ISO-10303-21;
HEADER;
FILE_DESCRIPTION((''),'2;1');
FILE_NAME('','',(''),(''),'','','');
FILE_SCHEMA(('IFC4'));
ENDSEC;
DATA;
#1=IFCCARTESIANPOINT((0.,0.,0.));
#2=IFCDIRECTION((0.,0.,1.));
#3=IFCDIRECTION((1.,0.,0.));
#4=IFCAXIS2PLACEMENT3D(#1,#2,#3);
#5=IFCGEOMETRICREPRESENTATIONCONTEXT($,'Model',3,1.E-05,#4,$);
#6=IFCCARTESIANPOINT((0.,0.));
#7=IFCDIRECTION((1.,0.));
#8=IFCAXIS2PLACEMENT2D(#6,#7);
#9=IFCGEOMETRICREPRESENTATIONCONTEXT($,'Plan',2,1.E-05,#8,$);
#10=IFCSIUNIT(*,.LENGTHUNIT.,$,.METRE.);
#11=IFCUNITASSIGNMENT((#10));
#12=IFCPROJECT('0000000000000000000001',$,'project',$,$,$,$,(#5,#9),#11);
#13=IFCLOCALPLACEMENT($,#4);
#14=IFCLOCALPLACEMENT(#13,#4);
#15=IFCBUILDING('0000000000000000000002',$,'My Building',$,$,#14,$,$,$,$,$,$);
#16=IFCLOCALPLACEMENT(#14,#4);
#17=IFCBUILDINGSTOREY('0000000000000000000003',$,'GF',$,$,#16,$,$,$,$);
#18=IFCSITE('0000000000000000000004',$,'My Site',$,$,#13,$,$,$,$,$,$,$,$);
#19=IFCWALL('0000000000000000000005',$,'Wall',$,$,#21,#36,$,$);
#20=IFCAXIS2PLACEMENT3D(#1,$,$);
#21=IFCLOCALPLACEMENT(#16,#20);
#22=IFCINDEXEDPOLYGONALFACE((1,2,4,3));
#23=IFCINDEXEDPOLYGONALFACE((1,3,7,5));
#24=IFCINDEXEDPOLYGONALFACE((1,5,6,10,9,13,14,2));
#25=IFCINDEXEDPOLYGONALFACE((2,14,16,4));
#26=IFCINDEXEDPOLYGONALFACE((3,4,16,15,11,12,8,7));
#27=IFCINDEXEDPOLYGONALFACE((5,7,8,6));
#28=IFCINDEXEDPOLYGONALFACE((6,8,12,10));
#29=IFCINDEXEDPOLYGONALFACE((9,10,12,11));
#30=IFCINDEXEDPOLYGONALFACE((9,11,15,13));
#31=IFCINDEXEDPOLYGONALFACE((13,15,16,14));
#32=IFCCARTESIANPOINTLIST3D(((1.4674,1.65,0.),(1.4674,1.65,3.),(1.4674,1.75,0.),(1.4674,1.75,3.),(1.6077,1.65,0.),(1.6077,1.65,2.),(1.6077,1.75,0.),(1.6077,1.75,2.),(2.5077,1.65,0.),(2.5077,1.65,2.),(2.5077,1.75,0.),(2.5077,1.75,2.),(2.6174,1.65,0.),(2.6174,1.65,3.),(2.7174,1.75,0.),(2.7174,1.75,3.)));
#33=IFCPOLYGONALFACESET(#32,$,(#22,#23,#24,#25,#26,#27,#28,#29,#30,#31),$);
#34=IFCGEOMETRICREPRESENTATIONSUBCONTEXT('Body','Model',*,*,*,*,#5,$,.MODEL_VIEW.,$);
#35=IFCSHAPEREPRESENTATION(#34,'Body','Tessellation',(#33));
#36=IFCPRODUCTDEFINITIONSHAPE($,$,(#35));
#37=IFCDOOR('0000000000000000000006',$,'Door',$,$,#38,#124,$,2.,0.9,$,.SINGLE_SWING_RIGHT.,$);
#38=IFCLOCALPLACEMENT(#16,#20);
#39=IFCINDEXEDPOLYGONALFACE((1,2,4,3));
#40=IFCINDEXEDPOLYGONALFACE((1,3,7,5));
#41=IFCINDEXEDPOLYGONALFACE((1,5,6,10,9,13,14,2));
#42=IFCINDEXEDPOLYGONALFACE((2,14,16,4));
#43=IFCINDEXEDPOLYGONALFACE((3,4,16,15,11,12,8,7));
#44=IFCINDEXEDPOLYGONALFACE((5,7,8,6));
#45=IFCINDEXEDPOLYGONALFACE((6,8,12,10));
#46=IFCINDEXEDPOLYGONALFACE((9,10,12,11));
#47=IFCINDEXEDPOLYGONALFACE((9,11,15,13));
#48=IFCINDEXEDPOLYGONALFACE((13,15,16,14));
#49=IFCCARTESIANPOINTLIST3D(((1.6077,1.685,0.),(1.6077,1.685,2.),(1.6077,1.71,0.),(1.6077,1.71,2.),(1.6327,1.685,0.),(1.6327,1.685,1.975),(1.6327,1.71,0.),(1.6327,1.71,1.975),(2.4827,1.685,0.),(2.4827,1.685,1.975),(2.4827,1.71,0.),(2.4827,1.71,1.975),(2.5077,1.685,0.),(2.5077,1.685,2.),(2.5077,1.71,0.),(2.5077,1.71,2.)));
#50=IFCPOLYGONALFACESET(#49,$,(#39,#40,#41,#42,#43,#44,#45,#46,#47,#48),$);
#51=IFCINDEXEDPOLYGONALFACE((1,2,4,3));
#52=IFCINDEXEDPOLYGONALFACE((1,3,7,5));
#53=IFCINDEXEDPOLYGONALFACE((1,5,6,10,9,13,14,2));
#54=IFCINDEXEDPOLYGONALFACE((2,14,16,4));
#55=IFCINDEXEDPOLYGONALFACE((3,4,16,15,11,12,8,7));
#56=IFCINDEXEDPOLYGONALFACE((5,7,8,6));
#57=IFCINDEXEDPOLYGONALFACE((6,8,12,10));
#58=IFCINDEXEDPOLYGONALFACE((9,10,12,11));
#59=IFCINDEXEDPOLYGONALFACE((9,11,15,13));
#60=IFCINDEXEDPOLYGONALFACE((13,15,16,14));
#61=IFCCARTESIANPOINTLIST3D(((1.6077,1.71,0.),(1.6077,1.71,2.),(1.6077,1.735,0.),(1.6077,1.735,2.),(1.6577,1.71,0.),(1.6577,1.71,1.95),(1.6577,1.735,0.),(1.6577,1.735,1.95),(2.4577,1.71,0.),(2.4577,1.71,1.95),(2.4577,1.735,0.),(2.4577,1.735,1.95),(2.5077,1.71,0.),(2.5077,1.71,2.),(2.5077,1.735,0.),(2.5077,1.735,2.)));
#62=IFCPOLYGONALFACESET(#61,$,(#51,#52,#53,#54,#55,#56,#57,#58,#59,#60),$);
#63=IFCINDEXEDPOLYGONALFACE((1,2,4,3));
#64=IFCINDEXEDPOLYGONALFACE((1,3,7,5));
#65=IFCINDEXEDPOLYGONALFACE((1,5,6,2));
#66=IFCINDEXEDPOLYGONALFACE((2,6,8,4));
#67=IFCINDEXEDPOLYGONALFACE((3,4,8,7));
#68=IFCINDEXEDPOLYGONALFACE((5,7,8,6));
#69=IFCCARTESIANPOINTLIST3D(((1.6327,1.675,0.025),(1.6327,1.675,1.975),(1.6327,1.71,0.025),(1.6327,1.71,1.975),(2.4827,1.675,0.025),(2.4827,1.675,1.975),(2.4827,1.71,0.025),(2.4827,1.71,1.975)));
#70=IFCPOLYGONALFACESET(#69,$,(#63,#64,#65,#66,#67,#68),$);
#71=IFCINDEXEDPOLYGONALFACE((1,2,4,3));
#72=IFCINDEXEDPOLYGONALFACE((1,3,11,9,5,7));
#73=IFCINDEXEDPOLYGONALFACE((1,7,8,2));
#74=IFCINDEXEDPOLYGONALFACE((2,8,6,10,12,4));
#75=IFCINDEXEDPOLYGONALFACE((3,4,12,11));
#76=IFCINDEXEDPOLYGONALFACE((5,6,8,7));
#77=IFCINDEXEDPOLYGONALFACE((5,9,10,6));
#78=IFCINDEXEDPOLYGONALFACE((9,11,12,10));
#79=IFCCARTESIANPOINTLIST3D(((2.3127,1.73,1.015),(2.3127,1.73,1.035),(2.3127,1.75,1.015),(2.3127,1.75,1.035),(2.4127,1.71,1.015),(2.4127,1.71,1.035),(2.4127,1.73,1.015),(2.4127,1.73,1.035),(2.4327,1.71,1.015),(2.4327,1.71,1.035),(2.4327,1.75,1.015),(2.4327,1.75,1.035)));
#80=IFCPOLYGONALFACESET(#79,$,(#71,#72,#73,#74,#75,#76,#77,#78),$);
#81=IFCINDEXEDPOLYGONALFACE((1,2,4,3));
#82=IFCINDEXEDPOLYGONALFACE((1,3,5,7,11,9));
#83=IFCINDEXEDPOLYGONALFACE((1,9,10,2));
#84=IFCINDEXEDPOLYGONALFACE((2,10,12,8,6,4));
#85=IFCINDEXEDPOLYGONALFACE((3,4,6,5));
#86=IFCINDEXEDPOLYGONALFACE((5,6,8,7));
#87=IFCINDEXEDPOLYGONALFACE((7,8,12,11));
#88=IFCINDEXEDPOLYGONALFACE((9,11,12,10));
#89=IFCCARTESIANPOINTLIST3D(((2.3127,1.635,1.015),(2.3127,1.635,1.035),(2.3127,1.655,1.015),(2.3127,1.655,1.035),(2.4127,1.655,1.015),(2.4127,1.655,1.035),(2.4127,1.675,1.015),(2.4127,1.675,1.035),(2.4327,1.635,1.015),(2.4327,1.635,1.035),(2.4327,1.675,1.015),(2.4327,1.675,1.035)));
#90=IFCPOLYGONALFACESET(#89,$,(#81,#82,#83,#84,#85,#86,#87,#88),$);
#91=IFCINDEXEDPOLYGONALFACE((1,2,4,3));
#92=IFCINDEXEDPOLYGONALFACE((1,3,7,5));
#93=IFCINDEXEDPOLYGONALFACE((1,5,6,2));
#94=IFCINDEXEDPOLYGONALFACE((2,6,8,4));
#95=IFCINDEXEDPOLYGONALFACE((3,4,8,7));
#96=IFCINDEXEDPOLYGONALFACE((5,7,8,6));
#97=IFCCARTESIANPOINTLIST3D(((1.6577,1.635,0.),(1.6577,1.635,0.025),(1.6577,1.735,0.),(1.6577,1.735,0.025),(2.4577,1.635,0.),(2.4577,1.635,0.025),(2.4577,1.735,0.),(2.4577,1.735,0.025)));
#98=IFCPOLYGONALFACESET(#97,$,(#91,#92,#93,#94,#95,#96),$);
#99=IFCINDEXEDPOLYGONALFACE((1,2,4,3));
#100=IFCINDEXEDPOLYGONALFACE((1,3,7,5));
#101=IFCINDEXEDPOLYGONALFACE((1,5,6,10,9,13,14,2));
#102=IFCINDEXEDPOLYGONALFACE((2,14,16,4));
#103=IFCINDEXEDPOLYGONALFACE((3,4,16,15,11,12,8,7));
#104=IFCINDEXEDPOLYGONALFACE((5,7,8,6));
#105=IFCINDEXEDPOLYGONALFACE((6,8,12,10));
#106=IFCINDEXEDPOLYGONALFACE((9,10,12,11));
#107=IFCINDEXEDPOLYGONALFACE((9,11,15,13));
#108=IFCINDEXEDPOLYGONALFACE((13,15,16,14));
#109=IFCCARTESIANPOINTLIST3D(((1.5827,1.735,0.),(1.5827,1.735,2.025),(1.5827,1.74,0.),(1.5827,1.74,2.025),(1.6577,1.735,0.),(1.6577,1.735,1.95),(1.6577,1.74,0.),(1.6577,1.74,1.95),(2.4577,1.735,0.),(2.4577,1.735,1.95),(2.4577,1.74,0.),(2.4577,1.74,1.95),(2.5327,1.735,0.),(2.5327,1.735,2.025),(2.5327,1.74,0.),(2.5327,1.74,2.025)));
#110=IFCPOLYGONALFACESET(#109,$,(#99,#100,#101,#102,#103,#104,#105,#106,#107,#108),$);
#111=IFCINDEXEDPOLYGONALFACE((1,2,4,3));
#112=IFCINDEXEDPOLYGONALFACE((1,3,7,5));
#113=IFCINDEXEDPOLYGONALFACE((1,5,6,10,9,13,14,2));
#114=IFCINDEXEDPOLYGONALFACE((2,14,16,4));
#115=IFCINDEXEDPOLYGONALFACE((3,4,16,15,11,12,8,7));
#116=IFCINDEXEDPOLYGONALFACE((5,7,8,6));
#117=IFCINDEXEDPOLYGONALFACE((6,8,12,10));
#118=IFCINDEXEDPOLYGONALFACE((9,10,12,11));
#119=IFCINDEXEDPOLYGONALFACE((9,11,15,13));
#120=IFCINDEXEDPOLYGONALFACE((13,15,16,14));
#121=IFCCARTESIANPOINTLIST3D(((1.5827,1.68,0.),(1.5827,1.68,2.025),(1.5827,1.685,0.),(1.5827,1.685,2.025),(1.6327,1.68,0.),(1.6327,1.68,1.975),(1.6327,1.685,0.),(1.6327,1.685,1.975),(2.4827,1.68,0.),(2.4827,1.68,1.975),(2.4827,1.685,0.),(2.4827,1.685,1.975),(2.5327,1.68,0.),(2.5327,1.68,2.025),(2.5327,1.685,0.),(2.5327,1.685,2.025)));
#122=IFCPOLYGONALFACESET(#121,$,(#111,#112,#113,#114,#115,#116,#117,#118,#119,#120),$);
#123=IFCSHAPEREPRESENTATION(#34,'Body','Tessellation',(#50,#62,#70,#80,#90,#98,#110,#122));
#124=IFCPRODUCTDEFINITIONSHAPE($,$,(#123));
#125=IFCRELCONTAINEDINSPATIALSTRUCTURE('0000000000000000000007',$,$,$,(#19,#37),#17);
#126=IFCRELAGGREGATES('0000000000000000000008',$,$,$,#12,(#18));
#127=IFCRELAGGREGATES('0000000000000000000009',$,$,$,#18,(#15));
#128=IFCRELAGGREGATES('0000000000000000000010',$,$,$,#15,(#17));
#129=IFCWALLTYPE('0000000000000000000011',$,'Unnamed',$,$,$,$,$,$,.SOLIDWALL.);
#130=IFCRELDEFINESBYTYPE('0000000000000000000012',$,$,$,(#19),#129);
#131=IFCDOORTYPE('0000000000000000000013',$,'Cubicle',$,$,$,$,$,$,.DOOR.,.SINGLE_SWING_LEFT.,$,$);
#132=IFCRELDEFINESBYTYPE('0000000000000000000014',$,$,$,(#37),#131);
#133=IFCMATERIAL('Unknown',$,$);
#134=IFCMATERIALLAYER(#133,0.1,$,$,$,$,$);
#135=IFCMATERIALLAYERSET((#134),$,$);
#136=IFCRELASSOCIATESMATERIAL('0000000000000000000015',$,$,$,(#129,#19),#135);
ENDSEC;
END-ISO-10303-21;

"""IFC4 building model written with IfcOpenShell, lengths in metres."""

from ifc_helpers import new_model, entity, si_unit, frame, origin_with_axes, origin_2d_with_axis, place, context, subcontext, project, spatial, line, indexed_curve, outline, extrude, shape, source, transform, mapped, material, layer, layer_set, layer_usage, type_object, type_shapes, element, fill, save


model = new_model("IFC4")

# Units and contexts
model_context = context("Model", 3, precision=1e-05, world=origin_with_axes())
plan_context = context("Plan", 2, precision=1e-05, world=origin_2d_with_axis())
body_context_1 = subcontext(model_context, "Body", "Model", "MODEL_VIEW")
body_context_2 = subcontext(plan_context, "Body", "Plan", "PLAN_VIEW")
ifc_project = project(units=[si_unit("LENGTHUNIT", "METRE")], contexts=[model_context, plan_context])

# Site, building, storey
site_placement = place(None, origin_with_axes())
site = spatial("IfcSite", under=ifc_project, at=site_placement, Name="My Site")
building_placement = place(site_placement, origin_with_axes())
building = spatial("IfcBuilding", under=site, at=building_placement, Name="My Building")
storey_placement = place(building_placement, origin_with_axes())
storey = spatial("IfcBuildingStorey", under=building, at=storey_placement, Name="GF")

# Shared definitions
ifc_material = material(Name="Unknown")

# Shared definitions
ifc_layer_1 = layer(ifc_material, 0.1)
ifc_layer_set_1 = layer_set([ifc_layer_1])
wall_type = type_object("IfcWallType", Name="Unnamed", PredefinedType="SOLIDWALL", material=ifc_layer_set_1)

# Wall, opening, door
shared_shape_1 = source(origin_with_axes(), body_context_1, "Body", "SweptSolid", [
    extrude(outline(indexed_curve([(0.0, 0.0), (0.9, 0.0), (0.9, 2.0), (0.0, 2.0)], segments=[line(1, 2, 3, 4, 1)])), frame((0.0, -0.6, 0.0), z_axis=(0.0, -1.0, 0.0), x_axis=(1.0, 0.0, 0.0)), (0.0, 0.0, -1.0), 1.2),
])
door_type = type_object("IfcDoorType", Name="Cubicle", OperationType="SINGLE_SWING_LEFT", PredefinedType="DOOR")
shared_shape_2 = source(origin_with_axes(), body_context_1, "Body", "SweptSolid", [
    extrude(outline(indexed_curve([(0.0, 0.0), (0.0, 2.0), (0.9, 2.0), (0.9, 0.0), (0.875, 0.0), (0.875, 1.975), (0.025, 1.975), (0.025, 0.0)], segments=[line(1, 2, 3, 4, 5, 6, 7, 8, 1)])), frame((0.0, 0.025, 0.0), z_axis=(0.0, -1.0, 0.0), x_axis=(1.0, 0.0, 0.0)), (0.0, 0.0, -1.0), 0.025),
    extrude(outline(indexed_curve([(0.0, 0.0), (0.0, 2.0), (0.9, 2.0), (0.9, 0.0), (0.85, 0.0), (0.85, 1.95), (0.05, 1.95), (0.05, 0.0)], segments=[line(1, 2, 3, 4, 5, 6, 7, 8, 1)])), frame((0.0, 0.0, 0.0), z_axis=(0.0, -1.0, 0.0), x_axis=(1.0, 0.0, 0.0)), (0.0, 0.0, -1.0), 0.025),
    extrude(outline(indexed_curve([(0.0, 0.0), (0.85, 0.0), (0.85, 0.035), (0.0, 0.035)], segments=[line(1, 2, 3, 4, 1)])), frame((0.025, 0.025, 0.025), z_axis=(0.0, 0.0, 1.0), x_axis=(1.0, 0.0, 0.0)), (0.0, 0.0, 1.0), 1.95),
    extrude(outline(indexed_curve([(0.0, 0.0), (0.0, -0.04), (0.12, -0.04), (0.12, -0.02), (0.02, -0.02), (0.02, 0.0)], segments=[line(1, 2, 3, 4, 5, 6, 1)])), frame((0.075, 0.025, 1.015), z_axis=(0.0, 0.0, 1.0), x_axis=(1.0, 0.0, 0.0)), (0.0, 0.0, 1.0), 0.02),
    extrude(outline(indexed_curve([(0.0, 0.0), (0.0, 0.04), (0.12, 0.04), (0.12, 0.02), (0.02, 0.02), (0.02, 0.0)], segments=[line(1, 2, 3, 4, 5, 6, 1)])), frame((0.075, 0.06, 1.015), z_axis=(0.0, 0.0, 1.0), x_axis=(1.0, 0.0, 0.0)), (0.0, 0.0, 1.0), 0.02),
    extrude(outline(indexed_curve([(0.0, 0.0), (0.8, 0.0), (0.8, 0.1), (0.0, 0.1)], segments=[line(1, 2, 3, 4, 1)])), frame((0.05, 0.0, 0.0), z_axis=(0.0, 0.0, 1.0), x_axis=(1.0, 0.0, 0.0)), (0.0, 0.0, 1.0), 0.025),
    extrude(outline(indexed_curve([(0.0, 0.0), (0.0, 2.025), (0.95, 2.025), (0.95, 0.0), (0.875, 0.0), (0.875, 1.95), (0.075, 1.95), (0.075, 0.0)], segments=[line(1, 2, 3, 4, 5, 6, 7, 8, 1)])), frame((-0.025, -0.005, 0.0), z_axis=(0.0, -1.0, 0.0), x_axis=(1.0, 0.0, 0.0)), (0.0, 0.0, -1.0), 0.005),
    extrude(outline(indexed_curve([(0.0, 0.0), (0.0, 2.025), (0.95, 2.025), (0.95, 0.0), (0.9, 0.0), (0.9, 1.975), (0.05, 1.975), (0.05, 0.0)], segments=[line(1, 2, 3, 4, 5, 6, 7, 8, 1)])), frame((-0.025, 0.05, 0.0), z_axis=(0.0, -1.0, 0.0), x_axis=(1.0, 0.0, 0.0)), (0.0, 0.0, -1.0), 0.005),
])
shared_shape_3 = source(origin_with_axes(), body_context_2, "Body", "Curve2D", [
    entity("IfcIndexedPolyCurve", entity("IfcCartesianPointList2D", [[0.0, 0.0], [0.0, 0.05], [0.025, 0.05], [0.025, 0.025], [0.05, 0.025], [0.05, 0.0]]), [entity("IfcLineIndex", [1, 2, 3, 4, 5, 6, 1])]),
    entity("IfcIndexedPolyCurve", entity("IfcCartesianPointList2D", [[0.9, 0.0], [0.9, 0.05], [0.875, 0.05], [0.875, 0.025], [0.85, 0.025], [0.85, 0.0]]), [entity("IfcLineIndex", [1, 2, 3, 4, 5, 6, 1])]),
    entity("IfcTrimmedCurve", entity("IfcEllipse", entity("IfcAxis2Placement2D", entity("IfcCartesianPoint", [0.84, 0.05]), entity("IfcDirection", [1.0, 0.0])), 0.815, 0.85), [entity("IfcCartesianPoint", [0.84, 0.9])], [entity("IfcCartesianPoint", [0.025, 0.05])], True, "CARTESIAN"),
    entity("IfcIndexedPolyCurve", entity("IfcCartesianPointList2D", [[0.875, 0.05], [0.84, 0.05], [0.84, 0.9], [0.875, 0.9]]), [entity("IfcLineIndex", [1, 2, 3, 4, 1])]),
])
type_shapes(door_type, [shared_shape_2, shared_shape_3])
ifc_layer_usage_1 = layer_usage(ifc_layer_set_1, "AXIS2", "POSITIVE", 0.0)
wall_1_placement = place(storey_placement, frame((2.6174, 1.75, 0.0), z_axis=(0.0, 0.0, 1.0), x_axis=(-1.0, 0.0, 0.0)))
wall_1 = element("IfcWall", 1, at=wall_1_placement, inside=storey, type_object=wall_type, material=ifc_layer_usage_1, Name="Wall", context=body_context_1, shape_type="SweptSolid", body=[
    extrude(outline(indexed_curve([(-0.1, 0.0), (0.0, 0.1), (1.15, 0.1), (1.15, 0.0)], segments=[line(1, 2, 3, 4, 1)])), origin_with_axes(), (0.0, 0.0, 1.0), 3.0),
])
opening_1_placement = place(wall_1_placement, frame((0.1097, 0.015, 0.0), z_axis=(0.0, 0.0, 1.0), x_axis=(1.0, 0.0, 0.0)))
opening_1 = element("IfcOpeningElement", 2, at=opening_1_placement, cuts=wall_1, PredefinedType="OPENING", context=body_context_1, shape_type="MappedRepresentation", body=[
    mapped(shared_shape_1, transform((0.0, 0.0, 0.0), x_axis=(1.0, 0.0, 0.0), y_axis=(0.0, 1.0, 0.0), z_axis=(0.0, 0.0, 1.0), scale=1.0)),
])
door_1_placement = place(opening_1_placement, frame((0.0, 0.0, 0.0), z_axis=(0.0, 0.0, 1.0), x_axis=(1.0, 0.0, 0.0)))
door_1 = element("IfcDoor", 3, at=door_1_placement, inside=storey, type_object=door_type, Name="Door", OperationType="SINGLE_SWING_RIGHT", OverallHeight=2.0, OverallWidth=0.9, shapes=[
    shape(body_context_1, "Body", "MappedRepresentation", [mapped(shared_shape_2, transform((0.0, 0.0, 0.0), x_axis=(1.0, 0.0, 0.0), y_axis=(0.0, 1.0, 0.0), z_axis=(0.0, 0.0, 1.0), scale=1.0))]),
    shape(body_context_2, "Body", "MappedRepresentation", [mapped(shared_shape_3, transform((0.0, 0.0, 0.0), x_axis=(1.0, 0.0, 0.0), y_axis=(0.0, 1.0, 0.0), z_axis=(0.0, 0.0, 1.0), scale=1.0))]),
])
fill(opening_1, door_1)

save(model, "model.ifc")
